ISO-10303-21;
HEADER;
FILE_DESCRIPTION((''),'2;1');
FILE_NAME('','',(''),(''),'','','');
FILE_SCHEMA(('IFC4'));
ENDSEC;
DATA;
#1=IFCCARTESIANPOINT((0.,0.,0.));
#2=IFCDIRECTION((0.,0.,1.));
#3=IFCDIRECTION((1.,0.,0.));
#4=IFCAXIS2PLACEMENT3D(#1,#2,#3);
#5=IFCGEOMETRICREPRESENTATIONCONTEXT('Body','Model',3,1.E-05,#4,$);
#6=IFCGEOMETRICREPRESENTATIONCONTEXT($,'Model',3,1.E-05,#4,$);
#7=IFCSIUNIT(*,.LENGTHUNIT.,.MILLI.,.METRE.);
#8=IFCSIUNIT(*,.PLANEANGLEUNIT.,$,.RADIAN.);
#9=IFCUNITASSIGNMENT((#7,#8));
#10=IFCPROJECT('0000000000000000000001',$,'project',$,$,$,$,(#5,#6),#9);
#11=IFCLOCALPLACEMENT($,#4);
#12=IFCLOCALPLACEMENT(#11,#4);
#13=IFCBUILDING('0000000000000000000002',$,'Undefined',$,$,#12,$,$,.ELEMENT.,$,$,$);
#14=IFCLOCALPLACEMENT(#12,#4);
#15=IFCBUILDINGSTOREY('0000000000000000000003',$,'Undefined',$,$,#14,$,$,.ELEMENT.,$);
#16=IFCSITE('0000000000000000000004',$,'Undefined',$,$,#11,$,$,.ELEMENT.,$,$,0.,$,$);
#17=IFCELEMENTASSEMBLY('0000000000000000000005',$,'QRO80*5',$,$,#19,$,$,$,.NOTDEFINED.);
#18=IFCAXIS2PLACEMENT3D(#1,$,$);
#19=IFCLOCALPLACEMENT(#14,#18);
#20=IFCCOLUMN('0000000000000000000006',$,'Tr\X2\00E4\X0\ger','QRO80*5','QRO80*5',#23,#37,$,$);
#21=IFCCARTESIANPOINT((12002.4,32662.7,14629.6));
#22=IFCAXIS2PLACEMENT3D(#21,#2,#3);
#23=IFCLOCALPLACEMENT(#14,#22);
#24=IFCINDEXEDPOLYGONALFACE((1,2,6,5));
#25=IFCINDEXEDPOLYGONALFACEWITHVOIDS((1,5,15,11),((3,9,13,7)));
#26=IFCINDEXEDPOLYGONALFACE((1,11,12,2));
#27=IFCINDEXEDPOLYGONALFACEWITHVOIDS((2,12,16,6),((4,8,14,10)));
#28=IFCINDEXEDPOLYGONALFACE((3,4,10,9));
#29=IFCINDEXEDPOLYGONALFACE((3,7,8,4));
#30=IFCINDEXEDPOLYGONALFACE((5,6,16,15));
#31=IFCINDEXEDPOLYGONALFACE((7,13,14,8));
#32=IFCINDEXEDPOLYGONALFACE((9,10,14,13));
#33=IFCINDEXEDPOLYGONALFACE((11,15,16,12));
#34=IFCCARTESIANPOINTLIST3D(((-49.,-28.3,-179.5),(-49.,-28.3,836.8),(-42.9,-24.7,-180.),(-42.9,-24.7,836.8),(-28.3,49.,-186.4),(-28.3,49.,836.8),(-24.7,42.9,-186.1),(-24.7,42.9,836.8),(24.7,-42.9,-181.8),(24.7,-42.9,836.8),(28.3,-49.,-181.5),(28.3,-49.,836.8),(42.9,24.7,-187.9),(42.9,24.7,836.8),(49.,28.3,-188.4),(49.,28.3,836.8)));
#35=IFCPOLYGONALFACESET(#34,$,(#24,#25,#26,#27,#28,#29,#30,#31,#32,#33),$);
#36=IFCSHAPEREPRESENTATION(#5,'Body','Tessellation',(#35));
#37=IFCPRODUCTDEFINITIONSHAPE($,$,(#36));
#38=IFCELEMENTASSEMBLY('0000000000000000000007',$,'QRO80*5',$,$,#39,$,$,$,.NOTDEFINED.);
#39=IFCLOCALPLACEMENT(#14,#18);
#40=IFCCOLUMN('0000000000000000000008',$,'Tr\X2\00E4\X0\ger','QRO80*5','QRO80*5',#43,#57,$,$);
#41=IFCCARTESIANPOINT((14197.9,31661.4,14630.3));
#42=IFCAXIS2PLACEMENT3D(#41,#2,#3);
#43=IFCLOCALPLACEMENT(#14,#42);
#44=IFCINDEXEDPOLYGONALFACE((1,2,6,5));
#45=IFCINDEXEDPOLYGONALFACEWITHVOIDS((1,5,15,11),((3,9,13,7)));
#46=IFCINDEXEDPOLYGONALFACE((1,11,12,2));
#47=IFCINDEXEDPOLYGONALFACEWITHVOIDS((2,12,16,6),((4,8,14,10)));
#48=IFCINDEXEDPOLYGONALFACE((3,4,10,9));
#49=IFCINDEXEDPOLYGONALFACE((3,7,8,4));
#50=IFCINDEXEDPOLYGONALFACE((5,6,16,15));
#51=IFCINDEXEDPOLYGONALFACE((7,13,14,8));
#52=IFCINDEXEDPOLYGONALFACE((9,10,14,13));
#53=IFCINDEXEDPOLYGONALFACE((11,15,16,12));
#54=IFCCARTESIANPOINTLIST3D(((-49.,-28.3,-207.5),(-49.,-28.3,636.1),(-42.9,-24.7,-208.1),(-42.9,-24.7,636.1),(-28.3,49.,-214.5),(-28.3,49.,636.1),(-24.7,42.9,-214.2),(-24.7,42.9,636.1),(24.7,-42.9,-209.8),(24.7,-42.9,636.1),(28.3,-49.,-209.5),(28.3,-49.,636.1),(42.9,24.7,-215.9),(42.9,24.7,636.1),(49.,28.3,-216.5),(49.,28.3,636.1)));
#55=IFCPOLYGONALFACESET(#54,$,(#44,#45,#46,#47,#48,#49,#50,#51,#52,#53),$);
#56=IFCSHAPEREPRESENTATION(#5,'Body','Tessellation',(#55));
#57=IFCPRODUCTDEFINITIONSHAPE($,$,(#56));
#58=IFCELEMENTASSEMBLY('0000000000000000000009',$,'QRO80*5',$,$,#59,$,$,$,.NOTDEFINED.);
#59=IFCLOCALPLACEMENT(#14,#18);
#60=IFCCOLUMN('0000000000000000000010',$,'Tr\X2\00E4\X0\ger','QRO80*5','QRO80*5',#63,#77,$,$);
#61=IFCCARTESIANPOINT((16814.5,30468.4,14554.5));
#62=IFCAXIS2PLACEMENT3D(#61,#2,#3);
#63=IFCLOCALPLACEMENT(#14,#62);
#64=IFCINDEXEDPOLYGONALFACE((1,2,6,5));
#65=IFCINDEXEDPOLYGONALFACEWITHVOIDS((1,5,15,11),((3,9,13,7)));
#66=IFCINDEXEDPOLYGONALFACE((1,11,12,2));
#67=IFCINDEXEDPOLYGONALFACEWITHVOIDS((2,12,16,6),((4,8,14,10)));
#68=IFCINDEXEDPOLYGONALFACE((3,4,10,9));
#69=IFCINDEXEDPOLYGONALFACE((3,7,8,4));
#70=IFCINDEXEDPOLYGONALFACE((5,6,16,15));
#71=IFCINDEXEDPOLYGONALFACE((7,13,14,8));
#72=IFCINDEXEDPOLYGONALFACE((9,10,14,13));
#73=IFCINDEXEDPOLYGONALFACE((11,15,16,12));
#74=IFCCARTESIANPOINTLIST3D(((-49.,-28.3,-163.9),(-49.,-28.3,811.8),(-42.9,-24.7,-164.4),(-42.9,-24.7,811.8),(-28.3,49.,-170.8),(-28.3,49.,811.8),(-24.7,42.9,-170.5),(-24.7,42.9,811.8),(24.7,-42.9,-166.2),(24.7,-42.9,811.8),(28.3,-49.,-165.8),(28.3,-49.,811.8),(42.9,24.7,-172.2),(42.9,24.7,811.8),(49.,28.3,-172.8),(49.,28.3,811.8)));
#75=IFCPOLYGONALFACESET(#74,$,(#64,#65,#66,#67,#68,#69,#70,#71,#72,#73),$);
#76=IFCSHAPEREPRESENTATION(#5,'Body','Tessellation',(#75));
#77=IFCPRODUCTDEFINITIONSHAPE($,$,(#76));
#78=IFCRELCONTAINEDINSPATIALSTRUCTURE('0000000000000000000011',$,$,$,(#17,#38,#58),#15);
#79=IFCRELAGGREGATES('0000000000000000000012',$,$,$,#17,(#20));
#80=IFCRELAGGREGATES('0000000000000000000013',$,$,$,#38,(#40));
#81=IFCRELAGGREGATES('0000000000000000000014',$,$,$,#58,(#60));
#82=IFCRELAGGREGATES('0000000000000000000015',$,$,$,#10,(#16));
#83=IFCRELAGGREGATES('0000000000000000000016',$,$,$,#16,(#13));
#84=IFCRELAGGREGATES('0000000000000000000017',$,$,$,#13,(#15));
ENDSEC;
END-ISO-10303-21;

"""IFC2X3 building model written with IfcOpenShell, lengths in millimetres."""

from ifc_helpers import new_model, si_unit, frame, origin_with_axes, origin_2d_with_axis, place, context, project, spatial, hollow_rectangle, extrude, clip, halfspace, element, aggregate, save


model = new_model("IFC2X3")

# Units and contexts
model_context_1 = context("Model", 3, precision=1e-05, world=origin_with_axes(), identifier="Body")
model_context_2 = context("Model", 3, precision=1e-05, world=origin_with_axes())
ifc_project = project(units=[si_unit("LENGTHUNIT", "METRE", prefix="MILLI"), si_unit("PLANEANGLEUNIT", "RADIAN")], contexts=[model_context_1, model_context_2])

# Site, building, storey
site_placement = place(None, origin_with_axes())
site = spatial("IfcSite", under=ifc_project, at=site_placement, Name="Undefined", CompositionType="ELEMENT", RefElevation=0.0)
building_placement = place(site_placement, origin_with_axes())
building = spatial("IfcBuilding", under=site, at=building_placement, Name="Undefined", CompositionType="ELEMENT")
storey_placement = place(building_placement, origin_with_axes())
storey = spatial("IfcBuildingStorey", under=building, at=storey_placement, Name="Undefined", CompositionType="ELEMENT")

# Element assemblies, columns
assembly_1 = element("IfcElementAssembly", 1, inside=storey, Name="QRO80*5", PredefinedType="NOTDEFINED")
column_1_placement = place(storey_placement, frame((12002.4, 32662.7, 14629.6), z_axis=(0.0, 0.0, 1.0), x_axis=(1.0, 0.0, 0.0)))
column_1 = element("IfcColumn", 2, at=column_1_placement, Name="Träger", Description="QRO80*5", ObjectType="QRO80*5", context=model_context_1, shape_type="Clipping", body=[
    clip(clip(extrude(hollow_rectangle(XDim=80.0, YDim=80.0, WallThickness=5.0, at=origin_2d_with_axis()), frame((0.0, 0.0, 836.8), z_axis=(0.0, 0.0, -1.0), x_axis=(-0.258926, -0.965897, -0.000005)), (0.0, 0.0, 1.0), 1025.2), halfspace(frame((-38.6, 10.4, 836.8), z_axis=(0.0, 0.0, -1.0), x_axis=(-0.258822, -0.965925, -0.000005)), True)), halfspace(frame((38.6, -10.4, -184.9), z_axis=(0.046369, 0.077477, 0.995915), x_axis=(-0.255865, -0.962806, 0.086814)), True)),
])
aggregate(assembly_1, [column_1])
assembly_2 = element("IfcElementAssembly", 3, inside=storey, Name="QRO80*5", PredefinedType="NOTDEFINED")
column_2_placement = place(storey_placement, frame((14197.9, 31661.4, 14630.3), z_axis=(0.0, 0.0, 1.0), x_axis=(1.0, 0.0, 0.0)))
column_2 = element("IfcColumn", 4, at=column_2_placement, Name="Träger", Description="QRO80*5", ObjectType="QRO80*5", context=model_context_1, shape_type="Clipping", body=[
    clip(clip(extrude(hollow_rectangle(XDim=80.0, YDim=80.0, WallThickness=5.0, at=origin_2d_with_axis()), frame((0.0, 0.0, 636.1), z_axis=(0.0, 0.0, -1.0), x_axis=(-0.25892, -0.965899, 0.000004)), (0.0, 0.0, 1.0), 852.6), halfspace(frame((38.6, -10.4, 636.1), z_axis=(0.0, 0.0, -1.0), x_axis=(0.258822, 0.965925, 0.000005)), True)), halfspace(frame((38.6, -10.4, -213.0), z_axis=(0.046304, 0.077236, 0.995937), x_axis=(-0.255872, -0.962827, 0.086565)), True)),
])
aggregate(assembly_2, [column_2])
assembly_3 = element("IfcElementAssembly", 5, inside=storey, Name="QRO80*5", PredefinedType="NOTDEFINED")
column_3_placement = place(storey_placement, frame((16814.5, 30468.4, 14554.5), z_axis=(0.0, 0.0, 1.0), x_axis=(1.0, 0.0, 0.0)))
column_3 = element("IfcColumn", 6, at=column_3_placement, Name="Träger", Description="QRO80*5", ObjectType="QRO80*5", context=model_context_1, shape_type="Clipping", body=[
    clip(clip(extrude(hollow_rectangle(XDim=80.0, YDim=80.0, WallThickness=5.0, at=origin_2d_with_axis()), frame((0.0, 0.0, 811.8), z_axis=(0.0, 0.0, -1.0), x_axis=(-0.258926, -0.965897, -0.000005)), (0.0, 0.0, 1.0), 984.7), halfspace(frame((38.6, -10.4, -169.3), z_axis=(0.046297, 0.077208, 0.99594), x_axis=(-0.255878, -0.962828, 0.086536)), True)), halfspace(frame((-38.6, 10.4, 811.8), z_axis=(0.0, 0.0, -1.0), x_axis=(-0.258822, -0.965925, -0.000005)), True)),
])
aggregate(assembly_3, [column_3])

save(model, "model.ifc")
